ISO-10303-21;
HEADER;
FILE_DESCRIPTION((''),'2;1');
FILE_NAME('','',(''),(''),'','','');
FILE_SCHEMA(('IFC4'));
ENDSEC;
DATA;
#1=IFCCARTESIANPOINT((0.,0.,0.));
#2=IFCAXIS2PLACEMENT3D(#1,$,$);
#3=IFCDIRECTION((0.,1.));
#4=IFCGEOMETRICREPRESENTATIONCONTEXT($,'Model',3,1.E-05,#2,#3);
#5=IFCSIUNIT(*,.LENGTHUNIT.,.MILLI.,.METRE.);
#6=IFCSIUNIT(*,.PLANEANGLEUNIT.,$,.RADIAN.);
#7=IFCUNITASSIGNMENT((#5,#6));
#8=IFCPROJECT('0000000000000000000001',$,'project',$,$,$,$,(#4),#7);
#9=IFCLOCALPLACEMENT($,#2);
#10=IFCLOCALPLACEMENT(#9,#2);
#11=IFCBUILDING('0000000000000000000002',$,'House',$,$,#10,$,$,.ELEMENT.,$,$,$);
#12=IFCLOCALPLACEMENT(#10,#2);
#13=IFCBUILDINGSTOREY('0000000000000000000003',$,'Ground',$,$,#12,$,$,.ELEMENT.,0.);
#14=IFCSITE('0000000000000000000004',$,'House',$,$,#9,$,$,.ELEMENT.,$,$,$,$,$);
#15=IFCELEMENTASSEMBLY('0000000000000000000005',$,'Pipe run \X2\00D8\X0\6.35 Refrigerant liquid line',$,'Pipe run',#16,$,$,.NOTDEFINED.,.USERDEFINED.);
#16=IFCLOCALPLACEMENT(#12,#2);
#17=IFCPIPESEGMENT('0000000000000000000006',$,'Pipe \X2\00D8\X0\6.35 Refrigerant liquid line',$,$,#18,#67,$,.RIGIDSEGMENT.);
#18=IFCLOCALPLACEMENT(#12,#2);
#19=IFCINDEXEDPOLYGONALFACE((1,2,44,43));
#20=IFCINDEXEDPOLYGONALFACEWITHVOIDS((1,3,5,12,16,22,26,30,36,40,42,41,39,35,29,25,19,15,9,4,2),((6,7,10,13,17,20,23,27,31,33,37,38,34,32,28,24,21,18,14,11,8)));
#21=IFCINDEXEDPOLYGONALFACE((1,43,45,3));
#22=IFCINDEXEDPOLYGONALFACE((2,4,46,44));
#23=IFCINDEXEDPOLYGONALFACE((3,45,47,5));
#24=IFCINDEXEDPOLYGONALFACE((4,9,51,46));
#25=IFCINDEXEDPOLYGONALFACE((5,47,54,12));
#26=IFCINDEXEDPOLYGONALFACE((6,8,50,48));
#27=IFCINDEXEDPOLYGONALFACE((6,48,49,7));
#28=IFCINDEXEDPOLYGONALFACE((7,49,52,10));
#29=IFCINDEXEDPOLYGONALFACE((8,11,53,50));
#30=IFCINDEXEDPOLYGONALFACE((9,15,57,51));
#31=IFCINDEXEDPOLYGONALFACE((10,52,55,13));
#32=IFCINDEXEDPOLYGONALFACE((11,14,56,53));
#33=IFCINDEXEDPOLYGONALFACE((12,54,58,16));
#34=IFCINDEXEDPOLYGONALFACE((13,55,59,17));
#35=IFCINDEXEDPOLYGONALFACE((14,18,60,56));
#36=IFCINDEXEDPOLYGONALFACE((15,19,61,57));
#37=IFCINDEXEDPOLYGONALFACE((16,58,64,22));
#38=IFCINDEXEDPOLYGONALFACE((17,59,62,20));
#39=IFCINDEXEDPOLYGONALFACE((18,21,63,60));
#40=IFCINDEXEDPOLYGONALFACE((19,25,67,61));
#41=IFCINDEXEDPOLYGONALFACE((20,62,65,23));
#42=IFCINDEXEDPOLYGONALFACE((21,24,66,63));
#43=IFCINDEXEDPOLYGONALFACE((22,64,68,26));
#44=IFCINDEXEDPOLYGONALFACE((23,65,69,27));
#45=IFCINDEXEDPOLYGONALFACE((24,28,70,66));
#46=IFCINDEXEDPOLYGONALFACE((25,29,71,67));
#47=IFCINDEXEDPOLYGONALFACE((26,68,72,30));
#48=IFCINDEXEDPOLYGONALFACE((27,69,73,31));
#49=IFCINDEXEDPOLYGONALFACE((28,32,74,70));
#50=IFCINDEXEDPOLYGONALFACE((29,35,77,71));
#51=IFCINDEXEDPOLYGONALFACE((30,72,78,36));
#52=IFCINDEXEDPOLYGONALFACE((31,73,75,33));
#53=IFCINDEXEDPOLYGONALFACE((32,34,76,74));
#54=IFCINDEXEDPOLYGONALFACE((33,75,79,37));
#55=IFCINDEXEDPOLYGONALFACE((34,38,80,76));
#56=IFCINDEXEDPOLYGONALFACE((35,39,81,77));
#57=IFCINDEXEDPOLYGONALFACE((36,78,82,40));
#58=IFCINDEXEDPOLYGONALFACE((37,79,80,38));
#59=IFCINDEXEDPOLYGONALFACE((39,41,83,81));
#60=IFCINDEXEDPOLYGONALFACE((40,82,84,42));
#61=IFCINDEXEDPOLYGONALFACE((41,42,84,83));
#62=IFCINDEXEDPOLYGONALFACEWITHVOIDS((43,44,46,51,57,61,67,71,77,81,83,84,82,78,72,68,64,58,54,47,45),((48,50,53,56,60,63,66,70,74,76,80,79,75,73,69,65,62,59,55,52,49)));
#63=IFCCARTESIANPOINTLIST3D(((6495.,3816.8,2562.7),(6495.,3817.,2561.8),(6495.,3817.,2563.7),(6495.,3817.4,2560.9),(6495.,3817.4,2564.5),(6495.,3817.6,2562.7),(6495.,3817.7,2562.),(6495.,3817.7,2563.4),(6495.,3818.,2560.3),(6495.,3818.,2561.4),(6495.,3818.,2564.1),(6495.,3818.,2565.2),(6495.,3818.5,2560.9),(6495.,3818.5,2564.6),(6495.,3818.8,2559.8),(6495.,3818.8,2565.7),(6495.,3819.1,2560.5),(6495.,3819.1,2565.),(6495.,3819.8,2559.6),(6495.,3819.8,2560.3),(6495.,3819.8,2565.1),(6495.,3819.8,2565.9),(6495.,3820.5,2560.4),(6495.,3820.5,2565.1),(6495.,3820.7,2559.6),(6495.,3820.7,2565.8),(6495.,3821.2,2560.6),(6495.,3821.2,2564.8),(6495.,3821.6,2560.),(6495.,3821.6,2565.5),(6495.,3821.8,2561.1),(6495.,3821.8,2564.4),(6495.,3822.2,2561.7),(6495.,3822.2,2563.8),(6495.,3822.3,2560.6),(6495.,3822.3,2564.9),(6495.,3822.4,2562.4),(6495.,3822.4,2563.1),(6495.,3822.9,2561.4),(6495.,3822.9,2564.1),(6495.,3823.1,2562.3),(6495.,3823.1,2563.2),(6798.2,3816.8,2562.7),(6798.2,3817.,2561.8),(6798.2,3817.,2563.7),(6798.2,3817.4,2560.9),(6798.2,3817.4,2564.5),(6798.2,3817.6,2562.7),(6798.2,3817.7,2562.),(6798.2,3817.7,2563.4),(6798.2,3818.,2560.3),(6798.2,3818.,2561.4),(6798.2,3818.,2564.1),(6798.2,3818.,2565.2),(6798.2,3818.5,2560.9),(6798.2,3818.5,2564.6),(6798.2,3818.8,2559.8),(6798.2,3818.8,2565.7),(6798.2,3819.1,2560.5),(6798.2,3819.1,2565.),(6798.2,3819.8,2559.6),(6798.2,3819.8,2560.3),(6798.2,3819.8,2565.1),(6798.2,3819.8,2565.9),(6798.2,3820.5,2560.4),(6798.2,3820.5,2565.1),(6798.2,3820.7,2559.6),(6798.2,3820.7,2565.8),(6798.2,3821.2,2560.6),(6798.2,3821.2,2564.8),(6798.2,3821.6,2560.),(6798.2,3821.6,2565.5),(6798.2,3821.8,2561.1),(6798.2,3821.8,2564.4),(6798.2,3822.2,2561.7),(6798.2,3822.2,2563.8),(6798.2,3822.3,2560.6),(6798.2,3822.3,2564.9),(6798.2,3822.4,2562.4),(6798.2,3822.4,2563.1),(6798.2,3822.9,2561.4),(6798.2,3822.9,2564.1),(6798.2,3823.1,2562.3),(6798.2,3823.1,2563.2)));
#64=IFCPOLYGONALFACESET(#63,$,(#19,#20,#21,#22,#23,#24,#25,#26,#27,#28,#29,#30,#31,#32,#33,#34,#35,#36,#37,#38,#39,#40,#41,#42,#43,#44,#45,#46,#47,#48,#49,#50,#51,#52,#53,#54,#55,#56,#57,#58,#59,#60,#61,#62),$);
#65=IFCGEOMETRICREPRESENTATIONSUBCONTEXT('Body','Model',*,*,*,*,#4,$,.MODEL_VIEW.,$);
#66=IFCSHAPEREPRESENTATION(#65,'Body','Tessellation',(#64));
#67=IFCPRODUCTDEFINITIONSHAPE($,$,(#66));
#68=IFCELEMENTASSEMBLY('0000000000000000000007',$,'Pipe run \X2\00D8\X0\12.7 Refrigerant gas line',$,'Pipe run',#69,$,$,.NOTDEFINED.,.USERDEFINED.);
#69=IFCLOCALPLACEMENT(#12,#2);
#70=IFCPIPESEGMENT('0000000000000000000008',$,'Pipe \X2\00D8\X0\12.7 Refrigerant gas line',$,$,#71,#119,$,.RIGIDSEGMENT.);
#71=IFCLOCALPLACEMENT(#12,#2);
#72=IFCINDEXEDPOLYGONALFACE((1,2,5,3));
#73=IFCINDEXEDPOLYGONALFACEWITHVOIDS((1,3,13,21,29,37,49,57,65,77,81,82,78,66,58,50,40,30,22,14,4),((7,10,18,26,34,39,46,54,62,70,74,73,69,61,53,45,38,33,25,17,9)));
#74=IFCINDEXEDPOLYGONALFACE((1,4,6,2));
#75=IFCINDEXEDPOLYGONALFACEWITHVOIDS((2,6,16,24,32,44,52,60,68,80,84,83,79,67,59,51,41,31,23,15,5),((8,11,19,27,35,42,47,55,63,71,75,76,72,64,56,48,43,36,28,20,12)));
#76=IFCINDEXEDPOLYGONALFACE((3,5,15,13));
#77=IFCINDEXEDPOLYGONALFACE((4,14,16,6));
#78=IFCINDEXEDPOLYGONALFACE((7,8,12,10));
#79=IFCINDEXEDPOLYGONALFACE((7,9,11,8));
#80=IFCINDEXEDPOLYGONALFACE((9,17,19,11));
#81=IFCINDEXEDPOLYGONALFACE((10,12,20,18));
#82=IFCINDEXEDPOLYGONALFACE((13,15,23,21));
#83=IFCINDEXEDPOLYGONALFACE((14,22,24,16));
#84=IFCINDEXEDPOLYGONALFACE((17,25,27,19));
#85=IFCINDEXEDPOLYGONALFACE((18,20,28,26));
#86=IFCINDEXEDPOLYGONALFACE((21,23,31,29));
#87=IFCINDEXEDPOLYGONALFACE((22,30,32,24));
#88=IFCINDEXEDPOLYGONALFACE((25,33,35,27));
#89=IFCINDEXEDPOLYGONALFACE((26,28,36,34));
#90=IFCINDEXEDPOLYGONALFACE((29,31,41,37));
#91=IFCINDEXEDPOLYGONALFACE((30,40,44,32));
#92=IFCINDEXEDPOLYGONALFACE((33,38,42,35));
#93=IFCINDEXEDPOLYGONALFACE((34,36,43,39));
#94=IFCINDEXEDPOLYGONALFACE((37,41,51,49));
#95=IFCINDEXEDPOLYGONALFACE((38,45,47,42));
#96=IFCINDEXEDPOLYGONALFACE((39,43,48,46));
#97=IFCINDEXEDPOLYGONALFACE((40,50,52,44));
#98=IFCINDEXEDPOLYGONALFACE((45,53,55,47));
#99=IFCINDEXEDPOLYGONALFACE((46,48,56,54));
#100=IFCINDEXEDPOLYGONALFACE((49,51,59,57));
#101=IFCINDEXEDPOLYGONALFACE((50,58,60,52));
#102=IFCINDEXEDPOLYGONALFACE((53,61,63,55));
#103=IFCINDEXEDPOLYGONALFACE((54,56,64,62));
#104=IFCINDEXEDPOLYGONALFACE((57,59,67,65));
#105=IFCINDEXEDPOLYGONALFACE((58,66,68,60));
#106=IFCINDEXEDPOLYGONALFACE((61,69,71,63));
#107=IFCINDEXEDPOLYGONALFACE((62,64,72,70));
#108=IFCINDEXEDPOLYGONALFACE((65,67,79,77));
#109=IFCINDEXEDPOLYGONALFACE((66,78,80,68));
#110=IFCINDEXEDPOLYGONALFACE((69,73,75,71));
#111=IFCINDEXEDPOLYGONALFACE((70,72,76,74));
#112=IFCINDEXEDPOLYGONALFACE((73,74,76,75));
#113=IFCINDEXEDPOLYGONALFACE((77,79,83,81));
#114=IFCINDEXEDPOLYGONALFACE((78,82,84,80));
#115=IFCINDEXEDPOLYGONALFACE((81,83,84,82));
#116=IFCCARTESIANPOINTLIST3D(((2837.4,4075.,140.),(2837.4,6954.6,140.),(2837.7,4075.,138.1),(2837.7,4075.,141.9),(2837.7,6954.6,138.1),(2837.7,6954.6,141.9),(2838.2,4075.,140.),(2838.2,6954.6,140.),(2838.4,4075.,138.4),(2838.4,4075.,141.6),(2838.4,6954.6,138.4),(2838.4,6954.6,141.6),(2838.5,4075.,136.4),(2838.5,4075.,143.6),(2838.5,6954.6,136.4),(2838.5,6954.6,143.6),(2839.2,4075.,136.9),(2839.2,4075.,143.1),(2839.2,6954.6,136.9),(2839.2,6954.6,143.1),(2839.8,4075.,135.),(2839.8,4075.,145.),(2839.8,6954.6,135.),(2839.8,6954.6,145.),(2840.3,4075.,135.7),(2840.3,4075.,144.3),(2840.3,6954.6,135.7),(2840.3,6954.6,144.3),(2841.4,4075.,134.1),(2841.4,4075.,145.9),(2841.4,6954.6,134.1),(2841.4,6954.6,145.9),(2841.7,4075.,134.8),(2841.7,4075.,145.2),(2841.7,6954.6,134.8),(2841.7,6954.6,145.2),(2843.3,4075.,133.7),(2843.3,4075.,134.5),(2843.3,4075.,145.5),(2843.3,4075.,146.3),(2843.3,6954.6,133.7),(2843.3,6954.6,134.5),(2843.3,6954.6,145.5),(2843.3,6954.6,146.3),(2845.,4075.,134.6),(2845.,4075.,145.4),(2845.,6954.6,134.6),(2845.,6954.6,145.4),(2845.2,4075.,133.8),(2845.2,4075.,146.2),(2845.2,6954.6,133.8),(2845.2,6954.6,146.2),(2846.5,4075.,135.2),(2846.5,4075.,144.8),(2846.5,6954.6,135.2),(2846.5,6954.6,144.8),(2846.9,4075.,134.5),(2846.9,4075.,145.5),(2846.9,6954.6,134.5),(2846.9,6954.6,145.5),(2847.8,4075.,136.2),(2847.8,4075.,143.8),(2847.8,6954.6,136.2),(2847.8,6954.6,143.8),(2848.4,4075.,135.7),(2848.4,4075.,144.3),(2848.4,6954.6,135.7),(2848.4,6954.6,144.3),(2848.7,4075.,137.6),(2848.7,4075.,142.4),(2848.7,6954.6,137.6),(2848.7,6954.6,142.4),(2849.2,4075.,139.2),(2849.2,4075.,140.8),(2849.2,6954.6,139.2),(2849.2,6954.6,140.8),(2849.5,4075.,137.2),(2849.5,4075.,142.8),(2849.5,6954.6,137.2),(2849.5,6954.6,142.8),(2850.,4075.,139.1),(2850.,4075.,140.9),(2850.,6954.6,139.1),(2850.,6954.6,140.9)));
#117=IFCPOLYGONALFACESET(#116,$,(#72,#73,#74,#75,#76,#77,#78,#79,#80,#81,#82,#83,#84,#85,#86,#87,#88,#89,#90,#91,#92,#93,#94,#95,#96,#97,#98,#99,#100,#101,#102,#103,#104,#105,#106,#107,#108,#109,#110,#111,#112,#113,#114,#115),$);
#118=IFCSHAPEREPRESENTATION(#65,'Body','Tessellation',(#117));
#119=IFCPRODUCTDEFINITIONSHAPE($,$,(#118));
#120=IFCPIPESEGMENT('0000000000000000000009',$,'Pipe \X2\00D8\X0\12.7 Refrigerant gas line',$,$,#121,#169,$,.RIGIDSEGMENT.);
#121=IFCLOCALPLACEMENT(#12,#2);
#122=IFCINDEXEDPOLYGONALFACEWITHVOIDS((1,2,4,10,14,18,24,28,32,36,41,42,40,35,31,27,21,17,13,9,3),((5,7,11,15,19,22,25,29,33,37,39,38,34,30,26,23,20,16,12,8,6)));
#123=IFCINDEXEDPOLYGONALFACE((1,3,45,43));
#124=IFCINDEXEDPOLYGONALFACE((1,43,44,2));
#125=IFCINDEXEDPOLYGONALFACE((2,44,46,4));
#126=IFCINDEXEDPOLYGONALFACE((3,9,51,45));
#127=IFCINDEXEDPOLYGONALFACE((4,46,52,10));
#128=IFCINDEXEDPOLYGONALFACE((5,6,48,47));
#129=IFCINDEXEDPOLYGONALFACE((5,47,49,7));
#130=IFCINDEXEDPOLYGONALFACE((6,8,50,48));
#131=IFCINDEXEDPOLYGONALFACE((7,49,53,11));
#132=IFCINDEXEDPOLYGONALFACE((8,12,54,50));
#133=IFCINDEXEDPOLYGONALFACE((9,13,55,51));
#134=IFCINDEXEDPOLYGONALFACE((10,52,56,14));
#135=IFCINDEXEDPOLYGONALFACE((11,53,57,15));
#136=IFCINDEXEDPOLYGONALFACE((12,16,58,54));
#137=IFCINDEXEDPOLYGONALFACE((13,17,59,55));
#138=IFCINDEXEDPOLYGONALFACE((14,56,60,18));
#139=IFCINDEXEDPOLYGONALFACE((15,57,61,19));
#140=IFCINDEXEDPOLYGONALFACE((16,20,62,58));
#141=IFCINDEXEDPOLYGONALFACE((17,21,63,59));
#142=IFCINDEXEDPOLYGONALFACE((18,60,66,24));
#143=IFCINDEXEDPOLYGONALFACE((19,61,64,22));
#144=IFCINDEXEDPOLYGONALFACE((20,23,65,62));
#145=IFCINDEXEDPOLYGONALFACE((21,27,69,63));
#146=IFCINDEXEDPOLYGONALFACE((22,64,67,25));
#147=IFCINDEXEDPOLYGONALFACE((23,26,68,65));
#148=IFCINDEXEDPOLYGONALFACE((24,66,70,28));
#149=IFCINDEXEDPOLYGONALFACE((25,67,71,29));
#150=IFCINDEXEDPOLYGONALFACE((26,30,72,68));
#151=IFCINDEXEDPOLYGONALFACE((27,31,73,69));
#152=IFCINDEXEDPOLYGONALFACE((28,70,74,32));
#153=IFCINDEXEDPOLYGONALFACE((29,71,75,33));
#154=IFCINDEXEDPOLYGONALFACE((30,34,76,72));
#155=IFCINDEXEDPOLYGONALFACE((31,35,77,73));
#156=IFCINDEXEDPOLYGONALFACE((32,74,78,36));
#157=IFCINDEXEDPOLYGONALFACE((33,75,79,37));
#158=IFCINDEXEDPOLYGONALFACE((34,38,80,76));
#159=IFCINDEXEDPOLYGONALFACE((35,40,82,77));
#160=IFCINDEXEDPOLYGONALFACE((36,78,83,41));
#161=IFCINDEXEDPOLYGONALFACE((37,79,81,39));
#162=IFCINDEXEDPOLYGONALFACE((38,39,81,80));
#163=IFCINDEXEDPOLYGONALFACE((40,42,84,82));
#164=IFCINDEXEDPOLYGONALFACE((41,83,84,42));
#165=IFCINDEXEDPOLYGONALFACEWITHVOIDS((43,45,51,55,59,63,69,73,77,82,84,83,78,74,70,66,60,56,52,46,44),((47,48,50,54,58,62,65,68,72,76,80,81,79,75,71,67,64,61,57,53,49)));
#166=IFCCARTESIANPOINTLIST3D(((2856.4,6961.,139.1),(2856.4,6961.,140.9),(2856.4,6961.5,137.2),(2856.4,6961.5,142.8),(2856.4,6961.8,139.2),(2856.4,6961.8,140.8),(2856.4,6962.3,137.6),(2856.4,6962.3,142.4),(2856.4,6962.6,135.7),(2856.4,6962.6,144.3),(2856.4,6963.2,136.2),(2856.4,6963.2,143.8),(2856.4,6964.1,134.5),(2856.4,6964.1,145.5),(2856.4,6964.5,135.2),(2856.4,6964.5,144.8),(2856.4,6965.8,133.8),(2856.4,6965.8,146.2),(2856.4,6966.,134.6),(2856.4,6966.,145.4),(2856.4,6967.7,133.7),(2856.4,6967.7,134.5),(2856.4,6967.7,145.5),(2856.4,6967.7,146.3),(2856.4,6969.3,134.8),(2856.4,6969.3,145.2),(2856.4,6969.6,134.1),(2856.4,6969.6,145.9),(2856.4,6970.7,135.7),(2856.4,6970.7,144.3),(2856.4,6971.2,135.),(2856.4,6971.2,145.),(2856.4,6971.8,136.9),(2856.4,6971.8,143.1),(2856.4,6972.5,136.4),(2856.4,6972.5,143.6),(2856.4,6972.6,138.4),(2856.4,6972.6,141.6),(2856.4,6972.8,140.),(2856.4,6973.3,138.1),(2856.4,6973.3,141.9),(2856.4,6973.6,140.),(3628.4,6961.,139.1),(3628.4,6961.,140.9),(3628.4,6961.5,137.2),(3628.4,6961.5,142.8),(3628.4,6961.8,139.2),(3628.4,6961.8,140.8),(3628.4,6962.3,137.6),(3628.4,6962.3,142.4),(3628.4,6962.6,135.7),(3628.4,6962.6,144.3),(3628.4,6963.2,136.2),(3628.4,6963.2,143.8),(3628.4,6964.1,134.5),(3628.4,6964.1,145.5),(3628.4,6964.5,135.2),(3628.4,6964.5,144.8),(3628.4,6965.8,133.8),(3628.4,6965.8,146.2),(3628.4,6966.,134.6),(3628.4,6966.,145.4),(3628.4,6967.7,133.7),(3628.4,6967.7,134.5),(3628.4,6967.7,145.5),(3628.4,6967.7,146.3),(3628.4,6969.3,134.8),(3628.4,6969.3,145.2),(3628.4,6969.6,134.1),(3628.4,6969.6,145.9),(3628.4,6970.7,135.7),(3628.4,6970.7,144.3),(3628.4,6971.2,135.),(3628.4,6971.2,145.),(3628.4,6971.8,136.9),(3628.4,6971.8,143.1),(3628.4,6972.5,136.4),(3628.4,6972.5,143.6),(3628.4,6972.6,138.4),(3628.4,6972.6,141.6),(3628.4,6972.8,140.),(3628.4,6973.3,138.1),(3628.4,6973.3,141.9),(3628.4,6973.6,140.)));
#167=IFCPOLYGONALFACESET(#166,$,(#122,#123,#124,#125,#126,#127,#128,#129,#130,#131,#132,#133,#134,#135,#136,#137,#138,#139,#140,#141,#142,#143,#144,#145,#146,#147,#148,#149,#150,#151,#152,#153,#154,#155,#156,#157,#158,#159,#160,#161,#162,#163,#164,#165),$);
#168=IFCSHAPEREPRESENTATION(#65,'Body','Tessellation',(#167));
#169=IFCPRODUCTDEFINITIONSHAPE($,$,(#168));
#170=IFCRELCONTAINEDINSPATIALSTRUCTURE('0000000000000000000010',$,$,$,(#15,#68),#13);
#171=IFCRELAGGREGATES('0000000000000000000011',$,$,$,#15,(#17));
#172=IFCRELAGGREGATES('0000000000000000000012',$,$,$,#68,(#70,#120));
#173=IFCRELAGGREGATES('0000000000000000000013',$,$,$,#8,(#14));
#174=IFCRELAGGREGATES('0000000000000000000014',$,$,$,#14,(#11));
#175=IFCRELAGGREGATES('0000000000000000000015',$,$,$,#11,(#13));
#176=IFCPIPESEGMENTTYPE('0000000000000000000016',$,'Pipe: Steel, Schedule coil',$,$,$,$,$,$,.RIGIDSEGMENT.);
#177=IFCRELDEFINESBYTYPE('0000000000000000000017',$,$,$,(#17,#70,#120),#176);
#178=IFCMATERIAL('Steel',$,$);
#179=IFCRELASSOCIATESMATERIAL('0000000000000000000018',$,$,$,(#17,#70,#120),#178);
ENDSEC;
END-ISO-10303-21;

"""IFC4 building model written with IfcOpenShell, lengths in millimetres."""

from ifc_helpers import new_model, si_unit, direction, frame, origin, origin_with_axes, origin_2d, place, context, subcontext, project, spatial, hollow_circle, extrude, material, type_object, element, aggregate, save


model = new_model("IFC4")

# Units and contexts
model_context = context("Model", 3, precision=1e-05, world=origin(), true_north=direction((0.0, 1.0)))
body_context = subcontext(model_context, "Body", "Model", "MODEL_VIEW")
ifc_project = project(units=[si_unit("LENGTHUNIT", "METRE", prefix="MILLI"), si_unit("PLANEANGLEUNIT", "RADIAN")], contexts=[model_context])

# Site, building, storey
site_placement = place(None, origin())
site = spatial("IfcSite", under=ifc_project, at=site_placement, Name="House", CompositionType="ELEMENT")
building_placement = place(site_placement, origin())
building = spatial("IfcBuilding", under=site, at=building_placement, Name="House", CompositionType="ELEMENT")
storey_placement = place(building_placement, origin())
storey = spatial("IfcBuildingStorey", under=building, at=storey_placement, Name="Ground", CompositionType="ELEMENT", Elevation=0.0)

# Element assemblies, pipe segments
ifc_material = material(Name="Steel")
pipe_segment_type = type_object("IfcPipeSegmentType", Name="Pipe: Steel, Schedule coil", PredefinedType="RIGIDSEGMENT")
assembly_1_placement = place(storey_placement, origin_with_axes())
assembly_1 = element("IfcElementAssembly", 1, at=assembly_1_placement, inside=storey, Name="Pipe run Ø6.35 Refrigerant liquid line", ObjectType="Pipe run", AssemblyPlace="NOTDEFINED", PredefinedType="USERDEFINED")
pipe_segment_1_placement = place(storey_placement, origin_with_axes())
pipe_segment_1 = element("IfcPipeSegment", 2, at=pipe_segment_1_placement, type_object=pipe_segment_type, material=ifc_material, Name="Pipe Ø6.35 Refrigerant liquid line", PredefinedType="RIGIDSEGMENT", context=body_context, shape_type="SweptSolid", body=[
    extrude(hollow_circle(Radius=3.2, WallThickness=0.8, at=origin_2d()), frame((6798.2, 3820.0, 2562.7), z_axis=(-1.0, 0.0, 0.0), x_axis=(0.0, -1.0, 0.0)), (0.0, 0.0, 1.0), 303.2),
])
assembly_2_placement = place(storey_placement, origin_with_axes())
assembly_2 = element("IfcElementAssembly", 3, at=assembly_2_placement, inside=storey, Name="Pipe run Ø12.7 Refrigerant gas line", ObjectType="Pipe run", AssemblyPlace="NOTDEFINED", PredefinedType="USERDEFINED")
pipe_segment_2_placement = place(storey_placement, origin_with_axes())
pipe_segment_2 = element("IfcPipeSegment", 4, at=pipe_segment_2_placement, type_object=pipe_segment_type, material=ifc_material, Name="Pipe Ø12.7 Refrigerant gas line", PredefinedType="RIGIDSEGMENT", context=body_context, shape_type="SweptSolid", body=[
    extrude(hollow_circle(Radius=6.3, WallThickness=0.8, at=origin_2d()), frame((2843.7, 4075.0, 140.0), z_axis=(0.0, 1.0, 0.0), x_axis=(-1.0, 0.0, 0.0)), (0.0, 0.0, 1.0), 2879.6),
])
pipe_segment_3_placement = place(storey_placement, origin_with_axes())
pipe_segment_3 = element("IfcPipeSegment", 5, at=pipe_segment_3_placement, type_object=pipe_segment_type, material=ifc_material, Name="Pipe Ø12.7 Refrigerant gas line", PredefinedType="RIGIDSEGMENT", context=body_context, shape_type="SweptSolid", body=[
    extrude(hollow_circle(Radius=6.3, WallThickness=0.8, at=origin_2d()), frame((2856.4, 6967.3, 140.0), z_axis=(1.0, 0.0, 0.0), x_axis=(0.0, 1.0, 0.0)), (0.0, 0.0, 1.0), 771.9),
])

aggregate(assembly_1, [pipe_segment_1])
aggregate(assembly_2, [pipe_segment_2, pipe_segment_3])

save(model, "model.ifc")
